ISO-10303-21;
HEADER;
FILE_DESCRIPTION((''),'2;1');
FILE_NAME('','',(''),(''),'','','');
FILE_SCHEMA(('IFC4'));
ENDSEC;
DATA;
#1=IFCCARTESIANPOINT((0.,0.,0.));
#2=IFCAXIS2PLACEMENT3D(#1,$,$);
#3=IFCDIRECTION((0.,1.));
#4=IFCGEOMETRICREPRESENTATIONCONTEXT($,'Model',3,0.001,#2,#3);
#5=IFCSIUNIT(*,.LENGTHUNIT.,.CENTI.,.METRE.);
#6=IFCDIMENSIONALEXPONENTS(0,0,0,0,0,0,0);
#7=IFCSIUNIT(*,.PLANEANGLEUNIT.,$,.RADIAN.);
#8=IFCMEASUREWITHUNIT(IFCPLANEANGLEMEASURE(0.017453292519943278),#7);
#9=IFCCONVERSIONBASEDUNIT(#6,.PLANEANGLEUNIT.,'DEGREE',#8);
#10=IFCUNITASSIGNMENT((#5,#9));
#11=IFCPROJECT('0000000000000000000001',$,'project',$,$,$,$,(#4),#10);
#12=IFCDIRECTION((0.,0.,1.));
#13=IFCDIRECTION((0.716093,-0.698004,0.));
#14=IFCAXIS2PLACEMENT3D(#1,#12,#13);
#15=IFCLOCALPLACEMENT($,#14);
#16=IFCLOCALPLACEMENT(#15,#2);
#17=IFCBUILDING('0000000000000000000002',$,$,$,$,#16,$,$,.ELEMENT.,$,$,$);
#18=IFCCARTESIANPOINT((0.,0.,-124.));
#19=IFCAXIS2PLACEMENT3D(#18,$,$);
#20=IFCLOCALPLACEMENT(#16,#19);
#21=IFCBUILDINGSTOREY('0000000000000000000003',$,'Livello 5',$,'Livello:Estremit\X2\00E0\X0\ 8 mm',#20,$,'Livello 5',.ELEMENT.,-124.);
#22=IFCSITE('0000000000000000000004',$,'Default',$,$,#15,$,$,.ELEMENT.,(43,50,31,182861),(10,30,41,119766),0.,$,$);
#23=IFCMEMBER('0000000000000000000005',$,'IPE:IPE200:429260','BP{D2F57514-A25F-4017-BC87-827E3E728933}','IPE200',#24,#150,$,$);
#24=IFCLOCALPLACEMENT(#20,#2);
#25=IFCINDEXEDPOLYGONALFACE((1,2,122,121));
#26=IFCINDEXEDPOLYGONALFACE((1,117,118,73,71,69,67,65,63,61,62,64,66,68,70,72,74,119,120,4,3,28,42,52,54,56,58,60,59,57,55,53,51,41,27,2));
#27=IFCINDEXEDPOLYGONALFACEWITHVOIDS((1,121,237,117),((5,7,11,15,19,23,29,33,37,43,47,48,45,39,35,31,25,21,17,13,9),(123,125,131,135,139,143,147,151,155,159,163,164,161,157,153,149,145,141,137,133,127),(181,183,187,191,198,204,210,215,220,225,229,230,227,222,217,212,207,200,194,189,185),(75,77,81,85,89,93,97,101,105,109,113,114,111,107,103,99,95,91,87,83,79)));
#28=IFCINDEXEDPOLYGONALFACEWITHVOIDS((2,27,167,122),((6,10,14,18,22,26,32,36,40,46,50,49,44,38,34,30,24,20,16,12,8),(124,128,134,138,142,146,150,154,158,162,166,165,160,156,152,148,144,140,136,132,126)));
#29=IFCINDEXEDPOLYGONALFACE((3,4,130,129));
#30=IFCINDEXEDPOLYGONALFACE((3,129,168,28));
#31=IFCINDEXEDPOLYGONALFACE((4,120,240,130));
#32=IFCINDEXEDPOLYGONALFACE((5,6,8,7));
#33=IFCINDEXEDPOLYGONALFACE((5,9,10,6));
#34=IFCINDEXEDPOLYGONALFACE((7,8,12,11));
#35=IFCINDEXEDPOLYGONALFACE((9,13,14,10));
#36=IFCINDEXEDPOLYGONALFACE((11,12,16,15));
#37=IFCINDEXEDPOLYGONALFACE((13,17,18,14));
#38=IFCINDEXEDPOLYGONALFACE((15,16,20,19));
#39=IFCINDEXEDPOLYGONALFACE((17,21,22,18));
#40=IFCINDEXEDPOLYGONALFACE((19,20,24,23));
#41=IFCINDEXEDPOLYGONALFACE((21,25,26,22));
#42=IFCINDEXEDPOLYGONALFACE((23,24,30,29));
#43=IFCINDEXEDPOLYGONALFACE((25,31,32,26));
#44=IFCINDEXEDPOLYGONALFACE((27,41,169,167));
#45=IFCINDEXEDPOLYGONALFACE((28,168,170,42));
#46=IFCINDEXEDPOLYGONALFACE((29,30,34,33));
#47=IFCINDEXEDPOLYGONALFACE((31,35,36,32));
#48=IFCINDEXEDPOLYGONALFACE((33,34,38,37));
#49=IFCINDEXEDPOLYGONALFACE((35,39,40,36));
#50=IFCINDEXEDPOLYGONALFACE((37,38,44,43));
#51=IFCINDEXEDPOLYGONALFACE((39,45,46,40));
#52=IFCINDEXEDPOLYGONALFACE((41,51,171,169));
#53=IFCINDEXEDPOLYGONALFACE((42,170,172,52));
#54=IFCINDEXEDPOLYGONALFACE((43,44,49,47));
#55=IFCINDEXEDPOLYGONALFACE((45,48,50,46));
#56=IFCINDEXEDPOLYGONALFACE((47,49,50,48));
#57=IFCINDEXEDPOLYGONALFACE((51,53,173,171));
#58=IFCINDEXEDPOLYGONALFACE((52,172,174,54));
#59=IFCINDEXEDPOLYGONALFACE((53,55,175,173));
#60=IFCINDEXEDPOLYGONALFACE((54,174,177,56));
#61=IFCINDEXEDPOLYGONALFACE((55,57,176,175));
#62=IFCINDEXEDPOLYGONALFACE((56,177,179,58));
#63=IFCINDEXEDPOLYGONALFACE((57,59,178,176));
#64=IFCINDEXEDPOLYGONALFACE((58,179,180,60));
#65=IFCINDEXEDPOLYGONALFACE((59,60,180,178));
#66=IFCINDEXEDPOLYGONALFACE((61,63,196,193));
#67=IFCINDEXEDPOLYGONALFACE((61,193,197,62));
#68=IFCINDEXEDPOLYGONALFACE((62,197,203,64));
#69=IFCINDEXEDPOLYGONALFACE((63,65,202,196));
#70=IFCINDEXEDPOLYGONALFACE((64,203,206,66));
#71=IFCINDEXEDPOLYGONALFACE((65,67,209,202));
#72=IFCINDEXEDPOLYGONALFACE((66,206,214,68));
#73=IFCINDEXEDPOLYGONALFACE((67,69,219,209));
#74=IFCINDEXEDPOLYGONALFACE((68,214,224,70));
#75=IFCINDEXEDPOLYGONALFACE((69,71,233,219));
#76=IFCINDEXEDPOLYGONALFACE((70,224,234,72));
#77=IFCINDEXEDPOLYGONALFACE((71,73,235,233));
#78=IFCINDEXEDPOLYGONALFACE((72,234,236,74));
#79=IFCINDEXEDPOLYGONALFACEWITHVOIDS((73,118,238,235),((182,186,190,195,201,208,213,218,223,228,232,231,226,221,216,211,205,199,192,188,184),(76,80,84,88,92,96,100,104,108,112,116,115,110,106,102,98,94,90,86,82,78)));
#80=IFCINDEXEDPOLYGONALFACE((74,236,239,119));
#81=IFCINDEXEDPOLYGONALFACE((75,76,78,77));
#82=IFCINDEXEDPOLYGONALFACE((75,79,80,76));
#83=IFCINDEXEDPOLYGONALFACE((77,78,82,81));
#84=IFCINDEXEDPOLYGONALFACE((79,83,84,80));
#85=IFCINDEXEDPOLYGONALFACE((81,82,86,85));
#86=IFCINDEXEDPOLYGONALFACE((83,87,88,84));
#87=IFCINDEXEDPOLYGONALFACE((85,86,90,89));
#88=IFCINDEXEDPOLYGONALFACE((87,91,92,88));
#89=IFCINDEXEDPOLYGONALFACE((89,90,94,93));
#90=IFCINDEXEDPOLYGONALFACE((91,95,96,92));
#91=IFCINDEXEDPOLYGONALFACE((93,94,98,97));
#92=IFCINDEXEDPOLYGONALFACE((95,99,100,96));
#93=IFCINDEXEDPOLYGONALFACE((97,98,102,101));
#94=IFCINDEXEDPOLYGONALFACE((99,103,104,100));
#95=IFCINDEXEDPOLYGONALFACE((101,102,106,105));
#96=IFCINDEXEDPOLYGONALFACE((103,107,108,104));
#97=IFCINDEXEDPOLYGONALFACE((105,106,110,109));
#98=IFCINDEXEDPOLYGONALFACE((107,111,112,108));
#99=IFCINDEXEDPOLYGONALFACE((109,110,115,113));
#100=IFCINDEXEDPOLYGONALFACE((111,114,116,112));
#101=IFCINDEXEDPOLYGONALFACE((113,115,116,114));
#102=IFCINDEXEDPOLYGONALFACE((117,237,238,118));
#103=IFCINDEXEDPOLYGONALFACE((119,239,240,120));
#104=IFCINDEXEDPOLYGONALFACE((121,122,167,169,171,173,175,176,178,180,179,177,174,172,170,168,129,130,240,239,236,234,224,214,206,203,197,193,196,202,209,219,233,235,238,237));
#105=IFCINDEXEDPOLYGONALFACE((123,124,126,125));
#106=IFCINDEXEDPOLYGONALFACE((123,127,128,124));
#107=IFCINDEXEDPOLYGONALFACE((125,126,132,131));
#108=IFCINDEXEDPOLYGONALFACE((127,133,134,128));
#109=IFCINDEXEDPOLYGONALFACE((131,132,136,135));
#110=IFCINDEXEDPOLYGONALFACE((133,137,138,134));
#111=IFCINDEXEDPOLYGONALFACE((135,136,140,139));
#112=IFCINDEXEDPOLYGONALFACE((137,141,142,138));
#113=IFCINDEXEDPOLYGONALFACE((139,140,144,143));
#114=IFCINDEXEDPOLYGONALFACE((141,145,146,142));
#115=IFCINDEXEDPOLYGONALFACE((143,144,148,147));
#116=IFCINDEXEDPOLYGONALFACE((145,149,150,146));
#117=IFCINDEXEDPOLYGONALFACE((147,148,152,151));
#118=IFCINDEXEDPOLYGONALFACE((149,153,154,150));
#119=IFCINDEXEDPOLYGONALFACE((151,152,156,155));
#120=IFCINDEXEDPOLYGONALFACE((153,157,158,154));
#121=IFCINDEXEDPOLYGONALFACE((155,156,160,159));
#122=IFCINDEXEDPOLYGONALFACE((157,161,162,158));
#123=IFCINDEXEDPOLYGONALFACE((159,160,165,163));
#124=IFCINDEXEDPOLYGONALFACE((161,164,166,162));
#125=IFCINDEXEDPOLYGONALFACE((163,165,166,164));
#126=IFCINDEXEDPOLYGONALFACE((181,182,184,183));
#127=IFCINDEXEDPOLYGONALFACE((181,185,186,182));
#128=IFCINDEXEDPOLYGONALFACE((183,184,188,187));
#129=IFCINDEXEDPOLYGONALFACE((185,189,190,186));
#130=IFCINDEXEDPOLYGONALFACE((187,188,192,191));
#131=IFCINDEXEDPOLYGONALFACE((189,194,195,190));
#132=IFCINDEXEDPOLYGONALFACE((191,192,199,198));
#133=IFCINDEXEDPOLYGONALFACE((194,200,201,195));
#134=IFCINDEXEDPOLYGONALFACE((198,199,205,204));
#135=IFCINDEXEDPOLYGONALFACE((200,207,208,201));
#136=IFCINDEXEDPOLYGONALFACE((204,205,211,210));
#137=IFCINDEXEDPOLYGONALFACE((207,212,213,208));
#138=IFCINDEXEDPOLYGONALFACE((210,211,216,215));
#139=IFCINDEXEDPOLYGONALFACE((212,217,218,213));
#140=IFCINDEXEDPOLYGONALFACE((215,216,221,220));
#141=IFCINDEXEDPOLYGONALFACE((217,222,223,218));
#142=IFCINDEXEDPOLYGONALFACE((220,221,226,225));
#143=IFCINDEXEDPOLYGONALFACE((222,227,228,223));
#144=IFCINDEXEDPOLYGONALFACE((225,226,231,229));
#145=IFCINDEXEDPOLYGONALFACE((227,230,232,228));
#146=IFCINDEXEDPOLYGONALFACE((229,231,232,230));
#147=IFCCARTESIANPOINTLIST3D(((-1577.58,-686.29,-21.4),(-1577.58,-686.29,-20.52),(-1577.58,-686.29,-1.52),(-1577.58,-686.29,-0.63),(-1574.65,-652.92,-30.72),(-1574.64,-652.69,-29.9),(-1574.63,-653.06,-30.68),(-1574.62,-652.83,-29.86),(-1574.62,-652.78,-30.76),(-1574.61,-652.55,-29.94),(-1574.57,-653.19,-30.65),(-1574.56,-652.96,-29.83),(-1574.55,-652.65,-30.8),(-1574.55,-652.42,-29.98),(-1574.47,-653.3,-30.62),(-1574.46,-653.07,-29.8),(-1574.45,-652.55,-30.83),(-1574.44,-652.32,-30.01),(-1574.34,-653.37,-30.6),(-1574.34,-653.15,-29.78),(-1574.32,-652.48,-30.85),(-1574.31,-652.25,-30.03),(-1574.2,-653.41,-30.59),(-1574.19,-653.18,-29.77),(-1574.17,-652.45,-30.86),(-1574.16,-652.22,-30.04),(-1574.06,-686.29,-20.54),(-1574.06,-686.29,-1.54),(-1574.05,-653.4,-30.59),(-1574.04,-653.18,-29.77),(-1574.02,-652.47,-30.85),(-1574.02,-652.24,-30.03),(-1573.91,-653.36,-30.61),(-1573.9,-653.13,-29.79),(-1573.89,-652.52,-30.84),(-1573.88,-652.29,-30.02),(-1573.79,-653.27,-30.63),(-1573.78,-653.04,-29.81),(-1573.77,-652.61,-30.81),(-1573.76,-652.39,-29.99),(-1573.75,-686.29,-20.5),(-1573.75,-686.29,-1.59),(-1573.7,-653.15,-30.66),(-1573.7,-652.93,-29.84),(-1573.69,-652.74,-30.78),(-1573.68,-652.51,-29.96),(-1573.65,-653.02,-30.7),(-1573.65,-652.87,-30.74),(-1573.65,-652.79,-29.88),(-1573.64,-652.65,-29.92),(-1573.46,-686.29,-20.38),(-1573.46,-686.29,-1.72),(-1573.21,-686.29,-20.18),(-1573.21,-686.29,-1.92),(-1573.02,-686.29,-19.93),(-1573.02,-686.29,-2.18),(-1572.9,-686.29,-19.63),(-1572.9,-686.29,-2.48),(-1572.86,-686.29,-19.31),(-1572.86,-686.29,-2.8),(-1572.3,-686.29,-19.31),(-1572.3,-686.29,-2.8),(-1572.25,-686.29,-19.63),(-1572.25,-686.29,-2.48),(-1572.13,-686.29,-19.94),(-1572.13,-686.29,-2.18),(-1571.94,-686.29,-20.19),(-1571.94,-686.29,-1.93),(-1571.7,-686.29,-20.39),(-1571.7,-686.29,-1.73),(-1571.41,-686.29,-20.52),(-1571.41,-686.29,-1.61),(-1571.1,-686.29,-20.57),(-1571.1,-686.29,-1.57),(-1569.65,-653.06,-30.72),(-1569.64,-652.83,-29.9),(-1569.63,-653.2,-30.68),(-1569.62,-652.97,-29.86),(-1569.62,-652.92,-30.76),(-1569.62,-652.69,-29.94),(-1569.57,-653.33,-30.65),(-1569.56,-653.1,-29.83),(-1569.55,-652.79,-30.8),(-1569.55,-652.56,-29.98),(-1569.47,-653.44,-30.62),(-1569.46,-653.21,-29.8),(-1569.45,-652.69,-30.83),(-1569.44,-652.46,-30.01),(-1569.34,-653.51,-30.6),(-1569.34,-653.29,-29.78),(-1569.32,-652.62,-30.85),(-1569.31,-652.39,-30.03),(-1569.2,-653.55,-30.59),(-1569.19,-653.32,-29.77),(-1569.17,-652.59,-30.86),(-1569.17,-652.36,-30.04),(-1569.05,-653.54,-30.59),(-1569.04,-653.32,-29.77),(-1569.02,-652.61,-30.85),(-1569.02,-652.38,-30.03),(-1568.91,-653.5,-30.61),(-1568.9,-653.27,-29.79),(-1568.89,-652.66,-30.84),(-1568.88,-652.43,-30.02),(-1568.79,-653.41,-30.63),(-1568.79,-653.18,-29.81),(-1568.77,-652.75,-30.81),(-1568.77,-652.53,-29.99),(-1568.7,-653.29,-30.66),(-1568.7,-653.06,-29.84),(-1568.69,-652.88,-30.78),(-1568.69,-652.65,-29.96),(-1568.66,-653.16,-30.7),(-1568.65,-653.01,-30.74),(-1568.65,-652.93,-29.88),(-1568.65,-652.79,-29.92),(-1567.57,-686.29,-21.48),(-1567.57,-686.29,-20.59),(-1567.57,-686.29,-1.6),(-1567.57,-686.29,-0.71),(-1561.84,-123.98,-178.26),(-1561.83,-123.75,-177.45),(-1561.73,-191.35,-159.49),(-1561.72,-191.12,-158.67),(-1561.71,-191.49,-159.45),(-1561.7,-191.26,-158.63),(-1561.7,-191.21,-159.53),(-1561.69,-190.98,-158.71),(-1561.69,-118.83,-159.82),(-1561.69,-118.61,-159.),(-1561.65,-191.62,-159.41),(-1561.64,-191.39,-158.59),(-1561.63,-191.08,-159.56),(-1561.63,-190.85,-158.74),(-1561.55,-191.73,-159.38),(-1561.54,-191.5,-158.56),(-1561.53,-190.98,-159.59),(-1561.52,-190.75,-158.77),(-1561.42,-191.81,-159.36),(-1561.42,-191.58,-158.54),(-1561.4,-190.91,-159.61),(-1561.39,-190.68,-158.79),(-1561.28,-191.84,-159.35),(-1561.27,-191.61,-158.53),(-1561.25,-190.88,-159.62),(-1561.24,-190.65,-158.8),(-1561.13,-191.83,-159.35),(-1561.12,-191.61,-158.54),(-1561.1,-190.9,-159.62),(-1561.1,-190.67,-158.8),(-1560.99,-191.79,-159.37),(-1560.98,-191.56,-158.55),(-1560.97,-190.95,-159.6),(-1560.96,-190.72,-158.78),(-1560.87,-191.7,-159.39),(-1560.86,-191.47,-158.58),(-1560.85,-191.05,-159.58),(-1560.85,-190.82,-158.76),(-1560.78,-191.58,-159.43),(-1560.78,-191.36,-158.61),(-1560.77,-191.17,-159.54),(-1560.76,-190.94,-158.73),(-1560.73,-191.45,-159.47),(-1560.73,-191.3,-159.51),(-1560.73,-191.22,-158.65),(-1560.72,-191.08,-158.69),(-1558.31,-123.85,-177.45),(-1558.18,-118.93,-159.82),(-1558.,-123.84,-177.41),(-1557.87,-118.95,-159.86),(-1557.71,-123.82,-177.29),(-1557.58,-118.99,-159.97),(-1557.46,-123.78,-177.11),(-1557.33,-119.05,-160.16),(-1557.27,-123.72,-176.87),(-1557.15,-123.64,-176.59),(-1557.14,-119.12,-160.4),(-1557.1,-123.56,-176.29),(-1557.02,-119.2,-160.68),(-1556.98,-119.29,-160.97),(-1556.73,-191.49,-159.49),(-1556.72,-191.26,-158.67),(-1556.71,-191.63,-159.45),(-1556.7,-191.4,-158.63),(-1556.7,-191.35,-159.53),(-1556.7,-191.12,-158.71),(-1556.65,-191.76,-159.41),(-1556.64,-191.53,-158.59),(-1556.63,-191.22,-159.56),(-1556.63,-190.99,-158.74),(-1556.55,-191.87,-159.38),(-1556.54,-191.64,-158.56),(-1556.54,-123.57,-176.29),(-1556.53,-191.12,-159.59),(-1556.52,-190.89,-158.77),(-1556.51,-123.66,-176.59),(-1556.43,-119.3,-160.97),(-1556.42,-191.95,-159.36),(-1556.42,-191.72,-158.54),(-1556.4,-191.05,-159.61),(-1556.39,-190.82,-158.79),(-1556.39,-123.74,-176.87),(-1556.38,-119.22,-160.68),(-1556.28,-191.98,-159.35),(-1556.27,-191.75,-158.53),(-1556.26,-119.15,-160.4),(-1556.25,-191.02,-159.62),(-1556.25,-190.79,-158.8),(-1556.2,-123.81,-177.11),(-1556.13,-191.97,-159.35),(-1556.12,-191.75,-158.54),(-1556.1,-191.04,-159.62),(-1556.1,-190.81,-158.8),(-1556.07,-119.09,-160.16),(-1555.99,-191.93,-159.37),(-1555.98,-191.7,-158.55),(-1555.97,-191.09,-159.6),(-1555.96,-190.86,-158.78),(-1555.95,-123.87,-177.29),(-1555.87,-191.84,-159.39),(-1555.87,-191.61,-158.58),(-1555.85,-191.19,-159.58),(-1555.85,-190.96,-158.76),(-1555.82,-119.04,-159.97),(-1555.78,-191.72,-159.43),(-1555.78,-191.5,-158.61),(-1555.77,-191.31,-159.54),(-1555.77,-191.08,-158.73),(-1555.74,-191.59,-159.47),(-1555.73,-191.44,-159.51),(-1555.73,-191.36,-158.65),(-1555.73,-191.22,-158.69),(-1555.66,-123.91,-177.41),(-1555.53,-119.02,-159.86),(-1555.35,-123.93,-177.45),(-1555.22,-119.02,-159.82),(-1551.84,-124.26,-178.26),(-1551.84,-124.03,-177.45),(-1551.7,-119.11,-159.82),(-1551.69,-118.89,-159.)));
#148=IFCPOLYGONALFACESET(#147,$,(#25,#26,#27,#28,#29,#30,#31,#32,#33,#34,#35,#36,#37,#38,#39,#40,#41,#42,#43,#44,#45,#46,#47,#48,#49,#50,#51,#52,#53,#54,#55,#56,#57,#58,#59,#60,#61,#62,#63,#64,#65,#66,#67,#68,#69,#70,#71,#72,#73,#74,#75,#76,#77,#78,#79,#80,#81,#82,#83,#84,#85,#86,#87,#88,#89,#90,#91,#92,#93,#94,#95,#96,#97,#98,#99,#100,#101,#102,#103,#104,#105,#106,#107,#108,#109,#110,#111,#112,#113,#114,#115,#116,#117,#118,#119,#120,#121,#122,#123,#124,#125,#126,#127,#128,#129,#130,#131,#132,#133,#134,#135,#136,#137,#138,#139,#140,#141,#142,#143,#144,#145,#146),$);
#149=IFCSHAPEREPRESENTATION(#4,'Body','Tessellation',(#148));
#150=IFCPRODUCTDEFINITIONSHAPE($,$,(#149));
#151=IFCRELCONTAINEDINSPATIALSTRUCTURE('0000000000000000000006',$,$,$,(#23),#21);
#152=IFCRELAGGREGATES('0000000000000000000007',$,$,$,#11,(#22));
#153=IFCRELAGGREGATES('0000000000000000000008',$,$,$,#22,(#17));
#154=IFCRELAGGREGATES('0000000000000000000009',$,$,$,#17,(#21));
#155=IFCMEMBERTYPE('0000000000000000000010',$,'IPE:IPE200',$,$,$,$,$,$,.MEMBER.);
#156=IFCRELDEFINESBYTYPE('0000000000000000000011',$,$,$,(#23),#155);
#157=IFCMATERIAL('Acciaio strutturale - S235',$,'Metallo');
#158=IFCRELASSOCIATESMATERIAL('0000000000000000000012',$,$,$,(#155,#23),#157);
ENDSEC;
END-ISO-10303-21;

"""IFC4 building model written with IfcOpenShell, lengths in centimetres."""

from ifc_helpers import new_model, entity, si_unit, converted_unit, direction, frame, frame_2d, origin, origin_2d, place, context, project, spatial, circle, i_section, extrude, clip, halfspace, material, type_object, element, save


model = new_model("IFC4")

# Units and contexts
model_context = context("Model", 3, precision=0.001, world=origin(), true_north=direction((0.0, 1.0)))
ifc_project = project(units=[si_unit("LENGTHUNIT", "METRE", prefix="CENTI"), converted_unit("PLANEANGLEUNIT", "DEGREE", entity("IfcPlaneAngleMeasure", 0.017453292519943278), si_unit("PLANEANGLEUNIT", "RADIAN"), dimensions=[0, 0, 0, 0, 0, 0, 0])], contexts=[model_context])

# Site, building, storey
site_placement = place(None, frame((0.0, 0.0, 0.0), z_axis=(0.0, 0.0, 1.0), x_axis=(0.716093, -0.698004, 0.0)))
site = spatial("IfcSite", under=ifc_project, at=site_placement, Name="Default", CompositionType="ELEMENT", RefLatitude=(43, 50, 31, 182861), RefLongitude=(10, 30, 41, 119766), RefElevation=0.0)
building_placement = place(site_placement, origin())
building = spatial("IfcBuilding", under=site, at=building_placement, CompositionType="ELEMENT")
storey_placement = place(building_placement, frame((0.0, 0.0, -124.0)))
storey = spatial("IfcBuildingStorey", under=building, at=storey_placement, Name="Livello 5", ObjectType="Livello:Estremità 8 mm", LongName="Livello 5", CompositionType="ELEMENT", Elevation=-124.0)

# Shared definitions
ifc_material_1 = material(Name="Acciaio strutturale - S235", Category="Metallo")

# Member, openings
member_type_1 = type_object("IfcMemberType", Name="IPE:IPE200", PredefinedType="MEMBER", material=ifc_material_1)
member_1_placement = place(storey_placement, frame((-1573.69, -726.15, 0.07), z_axis=(-0.026952, -0.962871, 0.268612), x_axis=(0.999608, -0.02798, 0.0)))
member_1 = element("IfcMember", 1, at=member_1_placement, inside=storey, type_object=member_type_1, material=ifc_material_1, Name="IPE:IPE200:429260", Description="BP{D2F57514-A25F-4017-BC87-827E3E728933}", ObjectType="IPE200", context=model_context, shape_type="Clipping", body=[
    clip(extrude(i_section(OverallWidth=10.0, OverallDepth=20.0, WebThickness=0.56, FlangeThickness=0.85, FilletRadius=1.2, at=origin_2d()), origin(), (0.0, 0.0, -1.0), 628.04), halfspace(frame((1571.96, 141.91, -47.51), z_axis=(-0.02798, 0.268507, -0.962871), x_axis=(-0.999608, -0.007516, 0.026952)), True)),
])
opening_1_placement = place(member_1_placement, frame((2.0, -9.1, -78.76), z_axis=(0.0, 1.0, 0.0), x_axis=(-1.0, 0.0, 0.0)))
element("IfcOpeningElement", 2, at=opening_1_placement, cuts=member_1, ObjectType="Opening", context=model_context, shape_type="SweptSolid", body=[
    extrude(circle(Radius=0.5, at=frame_2d((-0.5, 0.0), x_axis=(1.0, 0.0))), origin(), (0.0, 0.0, -1.0), 0.95),
])
opening_2_placement = place(member_1_placement, frame((-3.0, -9.1, -78.76), z_axis=(0.0, 1.0, 0.0), x_axis=(-1.0, 0.0, 0.0)))
element("IfcOpeningElement", 3, at=opening_2_placement, cuts=member_1, ObjectType="Opening", context=model_context, shape_type="SweptSolid", body=[
    extrude(circle(Radius=0.5, at=frame_2d((-0.5, 0.0), x_axis=(1.0, 0.0))), origin(), (0.0, 0.0, -1.0), 0.95),
])
opening_3_placement = place(member_1_placement, frame((2.0, -9.1, -558.13), z_axis=(0.0, 1.0, 0.0), x_axis=(-1.0, 0.0, 0.0)))
element("IfcOpeningElement", 4, at=opening_3_placement, cuts=member_1, ObjectType="Opening", context=model_context, shape_type="SweptSolid", body=[
    extrude(circle(Radius=0.5, at=frame_2d((-0.5, 0.0), x_axis=(1.0, 0.0))), origin(), (0.0, 0.0, -1.0), 0.95),
])
opening_4_placement = place(member_1_placement, frame((-3.0, -9.1, -558.13), z_axis=(0.0, 1.0, 0.0), x_axis=(-1.0, 0.0, 0.0)))
element("IfcOpeningElement", 5, at=opening_4_placement, cuts=member_1, ObjectType="Opening", context=model_context, shape_type="SweptSolid", body=[
    extrude(circle(Radius=0.5, at=frame_2d((-0.5, 0.0), x_axis=(1.0, 0.0))), origin(), (0.0, 0.0, -1.0), 0.95),
])

save(model, "model.ifc")
